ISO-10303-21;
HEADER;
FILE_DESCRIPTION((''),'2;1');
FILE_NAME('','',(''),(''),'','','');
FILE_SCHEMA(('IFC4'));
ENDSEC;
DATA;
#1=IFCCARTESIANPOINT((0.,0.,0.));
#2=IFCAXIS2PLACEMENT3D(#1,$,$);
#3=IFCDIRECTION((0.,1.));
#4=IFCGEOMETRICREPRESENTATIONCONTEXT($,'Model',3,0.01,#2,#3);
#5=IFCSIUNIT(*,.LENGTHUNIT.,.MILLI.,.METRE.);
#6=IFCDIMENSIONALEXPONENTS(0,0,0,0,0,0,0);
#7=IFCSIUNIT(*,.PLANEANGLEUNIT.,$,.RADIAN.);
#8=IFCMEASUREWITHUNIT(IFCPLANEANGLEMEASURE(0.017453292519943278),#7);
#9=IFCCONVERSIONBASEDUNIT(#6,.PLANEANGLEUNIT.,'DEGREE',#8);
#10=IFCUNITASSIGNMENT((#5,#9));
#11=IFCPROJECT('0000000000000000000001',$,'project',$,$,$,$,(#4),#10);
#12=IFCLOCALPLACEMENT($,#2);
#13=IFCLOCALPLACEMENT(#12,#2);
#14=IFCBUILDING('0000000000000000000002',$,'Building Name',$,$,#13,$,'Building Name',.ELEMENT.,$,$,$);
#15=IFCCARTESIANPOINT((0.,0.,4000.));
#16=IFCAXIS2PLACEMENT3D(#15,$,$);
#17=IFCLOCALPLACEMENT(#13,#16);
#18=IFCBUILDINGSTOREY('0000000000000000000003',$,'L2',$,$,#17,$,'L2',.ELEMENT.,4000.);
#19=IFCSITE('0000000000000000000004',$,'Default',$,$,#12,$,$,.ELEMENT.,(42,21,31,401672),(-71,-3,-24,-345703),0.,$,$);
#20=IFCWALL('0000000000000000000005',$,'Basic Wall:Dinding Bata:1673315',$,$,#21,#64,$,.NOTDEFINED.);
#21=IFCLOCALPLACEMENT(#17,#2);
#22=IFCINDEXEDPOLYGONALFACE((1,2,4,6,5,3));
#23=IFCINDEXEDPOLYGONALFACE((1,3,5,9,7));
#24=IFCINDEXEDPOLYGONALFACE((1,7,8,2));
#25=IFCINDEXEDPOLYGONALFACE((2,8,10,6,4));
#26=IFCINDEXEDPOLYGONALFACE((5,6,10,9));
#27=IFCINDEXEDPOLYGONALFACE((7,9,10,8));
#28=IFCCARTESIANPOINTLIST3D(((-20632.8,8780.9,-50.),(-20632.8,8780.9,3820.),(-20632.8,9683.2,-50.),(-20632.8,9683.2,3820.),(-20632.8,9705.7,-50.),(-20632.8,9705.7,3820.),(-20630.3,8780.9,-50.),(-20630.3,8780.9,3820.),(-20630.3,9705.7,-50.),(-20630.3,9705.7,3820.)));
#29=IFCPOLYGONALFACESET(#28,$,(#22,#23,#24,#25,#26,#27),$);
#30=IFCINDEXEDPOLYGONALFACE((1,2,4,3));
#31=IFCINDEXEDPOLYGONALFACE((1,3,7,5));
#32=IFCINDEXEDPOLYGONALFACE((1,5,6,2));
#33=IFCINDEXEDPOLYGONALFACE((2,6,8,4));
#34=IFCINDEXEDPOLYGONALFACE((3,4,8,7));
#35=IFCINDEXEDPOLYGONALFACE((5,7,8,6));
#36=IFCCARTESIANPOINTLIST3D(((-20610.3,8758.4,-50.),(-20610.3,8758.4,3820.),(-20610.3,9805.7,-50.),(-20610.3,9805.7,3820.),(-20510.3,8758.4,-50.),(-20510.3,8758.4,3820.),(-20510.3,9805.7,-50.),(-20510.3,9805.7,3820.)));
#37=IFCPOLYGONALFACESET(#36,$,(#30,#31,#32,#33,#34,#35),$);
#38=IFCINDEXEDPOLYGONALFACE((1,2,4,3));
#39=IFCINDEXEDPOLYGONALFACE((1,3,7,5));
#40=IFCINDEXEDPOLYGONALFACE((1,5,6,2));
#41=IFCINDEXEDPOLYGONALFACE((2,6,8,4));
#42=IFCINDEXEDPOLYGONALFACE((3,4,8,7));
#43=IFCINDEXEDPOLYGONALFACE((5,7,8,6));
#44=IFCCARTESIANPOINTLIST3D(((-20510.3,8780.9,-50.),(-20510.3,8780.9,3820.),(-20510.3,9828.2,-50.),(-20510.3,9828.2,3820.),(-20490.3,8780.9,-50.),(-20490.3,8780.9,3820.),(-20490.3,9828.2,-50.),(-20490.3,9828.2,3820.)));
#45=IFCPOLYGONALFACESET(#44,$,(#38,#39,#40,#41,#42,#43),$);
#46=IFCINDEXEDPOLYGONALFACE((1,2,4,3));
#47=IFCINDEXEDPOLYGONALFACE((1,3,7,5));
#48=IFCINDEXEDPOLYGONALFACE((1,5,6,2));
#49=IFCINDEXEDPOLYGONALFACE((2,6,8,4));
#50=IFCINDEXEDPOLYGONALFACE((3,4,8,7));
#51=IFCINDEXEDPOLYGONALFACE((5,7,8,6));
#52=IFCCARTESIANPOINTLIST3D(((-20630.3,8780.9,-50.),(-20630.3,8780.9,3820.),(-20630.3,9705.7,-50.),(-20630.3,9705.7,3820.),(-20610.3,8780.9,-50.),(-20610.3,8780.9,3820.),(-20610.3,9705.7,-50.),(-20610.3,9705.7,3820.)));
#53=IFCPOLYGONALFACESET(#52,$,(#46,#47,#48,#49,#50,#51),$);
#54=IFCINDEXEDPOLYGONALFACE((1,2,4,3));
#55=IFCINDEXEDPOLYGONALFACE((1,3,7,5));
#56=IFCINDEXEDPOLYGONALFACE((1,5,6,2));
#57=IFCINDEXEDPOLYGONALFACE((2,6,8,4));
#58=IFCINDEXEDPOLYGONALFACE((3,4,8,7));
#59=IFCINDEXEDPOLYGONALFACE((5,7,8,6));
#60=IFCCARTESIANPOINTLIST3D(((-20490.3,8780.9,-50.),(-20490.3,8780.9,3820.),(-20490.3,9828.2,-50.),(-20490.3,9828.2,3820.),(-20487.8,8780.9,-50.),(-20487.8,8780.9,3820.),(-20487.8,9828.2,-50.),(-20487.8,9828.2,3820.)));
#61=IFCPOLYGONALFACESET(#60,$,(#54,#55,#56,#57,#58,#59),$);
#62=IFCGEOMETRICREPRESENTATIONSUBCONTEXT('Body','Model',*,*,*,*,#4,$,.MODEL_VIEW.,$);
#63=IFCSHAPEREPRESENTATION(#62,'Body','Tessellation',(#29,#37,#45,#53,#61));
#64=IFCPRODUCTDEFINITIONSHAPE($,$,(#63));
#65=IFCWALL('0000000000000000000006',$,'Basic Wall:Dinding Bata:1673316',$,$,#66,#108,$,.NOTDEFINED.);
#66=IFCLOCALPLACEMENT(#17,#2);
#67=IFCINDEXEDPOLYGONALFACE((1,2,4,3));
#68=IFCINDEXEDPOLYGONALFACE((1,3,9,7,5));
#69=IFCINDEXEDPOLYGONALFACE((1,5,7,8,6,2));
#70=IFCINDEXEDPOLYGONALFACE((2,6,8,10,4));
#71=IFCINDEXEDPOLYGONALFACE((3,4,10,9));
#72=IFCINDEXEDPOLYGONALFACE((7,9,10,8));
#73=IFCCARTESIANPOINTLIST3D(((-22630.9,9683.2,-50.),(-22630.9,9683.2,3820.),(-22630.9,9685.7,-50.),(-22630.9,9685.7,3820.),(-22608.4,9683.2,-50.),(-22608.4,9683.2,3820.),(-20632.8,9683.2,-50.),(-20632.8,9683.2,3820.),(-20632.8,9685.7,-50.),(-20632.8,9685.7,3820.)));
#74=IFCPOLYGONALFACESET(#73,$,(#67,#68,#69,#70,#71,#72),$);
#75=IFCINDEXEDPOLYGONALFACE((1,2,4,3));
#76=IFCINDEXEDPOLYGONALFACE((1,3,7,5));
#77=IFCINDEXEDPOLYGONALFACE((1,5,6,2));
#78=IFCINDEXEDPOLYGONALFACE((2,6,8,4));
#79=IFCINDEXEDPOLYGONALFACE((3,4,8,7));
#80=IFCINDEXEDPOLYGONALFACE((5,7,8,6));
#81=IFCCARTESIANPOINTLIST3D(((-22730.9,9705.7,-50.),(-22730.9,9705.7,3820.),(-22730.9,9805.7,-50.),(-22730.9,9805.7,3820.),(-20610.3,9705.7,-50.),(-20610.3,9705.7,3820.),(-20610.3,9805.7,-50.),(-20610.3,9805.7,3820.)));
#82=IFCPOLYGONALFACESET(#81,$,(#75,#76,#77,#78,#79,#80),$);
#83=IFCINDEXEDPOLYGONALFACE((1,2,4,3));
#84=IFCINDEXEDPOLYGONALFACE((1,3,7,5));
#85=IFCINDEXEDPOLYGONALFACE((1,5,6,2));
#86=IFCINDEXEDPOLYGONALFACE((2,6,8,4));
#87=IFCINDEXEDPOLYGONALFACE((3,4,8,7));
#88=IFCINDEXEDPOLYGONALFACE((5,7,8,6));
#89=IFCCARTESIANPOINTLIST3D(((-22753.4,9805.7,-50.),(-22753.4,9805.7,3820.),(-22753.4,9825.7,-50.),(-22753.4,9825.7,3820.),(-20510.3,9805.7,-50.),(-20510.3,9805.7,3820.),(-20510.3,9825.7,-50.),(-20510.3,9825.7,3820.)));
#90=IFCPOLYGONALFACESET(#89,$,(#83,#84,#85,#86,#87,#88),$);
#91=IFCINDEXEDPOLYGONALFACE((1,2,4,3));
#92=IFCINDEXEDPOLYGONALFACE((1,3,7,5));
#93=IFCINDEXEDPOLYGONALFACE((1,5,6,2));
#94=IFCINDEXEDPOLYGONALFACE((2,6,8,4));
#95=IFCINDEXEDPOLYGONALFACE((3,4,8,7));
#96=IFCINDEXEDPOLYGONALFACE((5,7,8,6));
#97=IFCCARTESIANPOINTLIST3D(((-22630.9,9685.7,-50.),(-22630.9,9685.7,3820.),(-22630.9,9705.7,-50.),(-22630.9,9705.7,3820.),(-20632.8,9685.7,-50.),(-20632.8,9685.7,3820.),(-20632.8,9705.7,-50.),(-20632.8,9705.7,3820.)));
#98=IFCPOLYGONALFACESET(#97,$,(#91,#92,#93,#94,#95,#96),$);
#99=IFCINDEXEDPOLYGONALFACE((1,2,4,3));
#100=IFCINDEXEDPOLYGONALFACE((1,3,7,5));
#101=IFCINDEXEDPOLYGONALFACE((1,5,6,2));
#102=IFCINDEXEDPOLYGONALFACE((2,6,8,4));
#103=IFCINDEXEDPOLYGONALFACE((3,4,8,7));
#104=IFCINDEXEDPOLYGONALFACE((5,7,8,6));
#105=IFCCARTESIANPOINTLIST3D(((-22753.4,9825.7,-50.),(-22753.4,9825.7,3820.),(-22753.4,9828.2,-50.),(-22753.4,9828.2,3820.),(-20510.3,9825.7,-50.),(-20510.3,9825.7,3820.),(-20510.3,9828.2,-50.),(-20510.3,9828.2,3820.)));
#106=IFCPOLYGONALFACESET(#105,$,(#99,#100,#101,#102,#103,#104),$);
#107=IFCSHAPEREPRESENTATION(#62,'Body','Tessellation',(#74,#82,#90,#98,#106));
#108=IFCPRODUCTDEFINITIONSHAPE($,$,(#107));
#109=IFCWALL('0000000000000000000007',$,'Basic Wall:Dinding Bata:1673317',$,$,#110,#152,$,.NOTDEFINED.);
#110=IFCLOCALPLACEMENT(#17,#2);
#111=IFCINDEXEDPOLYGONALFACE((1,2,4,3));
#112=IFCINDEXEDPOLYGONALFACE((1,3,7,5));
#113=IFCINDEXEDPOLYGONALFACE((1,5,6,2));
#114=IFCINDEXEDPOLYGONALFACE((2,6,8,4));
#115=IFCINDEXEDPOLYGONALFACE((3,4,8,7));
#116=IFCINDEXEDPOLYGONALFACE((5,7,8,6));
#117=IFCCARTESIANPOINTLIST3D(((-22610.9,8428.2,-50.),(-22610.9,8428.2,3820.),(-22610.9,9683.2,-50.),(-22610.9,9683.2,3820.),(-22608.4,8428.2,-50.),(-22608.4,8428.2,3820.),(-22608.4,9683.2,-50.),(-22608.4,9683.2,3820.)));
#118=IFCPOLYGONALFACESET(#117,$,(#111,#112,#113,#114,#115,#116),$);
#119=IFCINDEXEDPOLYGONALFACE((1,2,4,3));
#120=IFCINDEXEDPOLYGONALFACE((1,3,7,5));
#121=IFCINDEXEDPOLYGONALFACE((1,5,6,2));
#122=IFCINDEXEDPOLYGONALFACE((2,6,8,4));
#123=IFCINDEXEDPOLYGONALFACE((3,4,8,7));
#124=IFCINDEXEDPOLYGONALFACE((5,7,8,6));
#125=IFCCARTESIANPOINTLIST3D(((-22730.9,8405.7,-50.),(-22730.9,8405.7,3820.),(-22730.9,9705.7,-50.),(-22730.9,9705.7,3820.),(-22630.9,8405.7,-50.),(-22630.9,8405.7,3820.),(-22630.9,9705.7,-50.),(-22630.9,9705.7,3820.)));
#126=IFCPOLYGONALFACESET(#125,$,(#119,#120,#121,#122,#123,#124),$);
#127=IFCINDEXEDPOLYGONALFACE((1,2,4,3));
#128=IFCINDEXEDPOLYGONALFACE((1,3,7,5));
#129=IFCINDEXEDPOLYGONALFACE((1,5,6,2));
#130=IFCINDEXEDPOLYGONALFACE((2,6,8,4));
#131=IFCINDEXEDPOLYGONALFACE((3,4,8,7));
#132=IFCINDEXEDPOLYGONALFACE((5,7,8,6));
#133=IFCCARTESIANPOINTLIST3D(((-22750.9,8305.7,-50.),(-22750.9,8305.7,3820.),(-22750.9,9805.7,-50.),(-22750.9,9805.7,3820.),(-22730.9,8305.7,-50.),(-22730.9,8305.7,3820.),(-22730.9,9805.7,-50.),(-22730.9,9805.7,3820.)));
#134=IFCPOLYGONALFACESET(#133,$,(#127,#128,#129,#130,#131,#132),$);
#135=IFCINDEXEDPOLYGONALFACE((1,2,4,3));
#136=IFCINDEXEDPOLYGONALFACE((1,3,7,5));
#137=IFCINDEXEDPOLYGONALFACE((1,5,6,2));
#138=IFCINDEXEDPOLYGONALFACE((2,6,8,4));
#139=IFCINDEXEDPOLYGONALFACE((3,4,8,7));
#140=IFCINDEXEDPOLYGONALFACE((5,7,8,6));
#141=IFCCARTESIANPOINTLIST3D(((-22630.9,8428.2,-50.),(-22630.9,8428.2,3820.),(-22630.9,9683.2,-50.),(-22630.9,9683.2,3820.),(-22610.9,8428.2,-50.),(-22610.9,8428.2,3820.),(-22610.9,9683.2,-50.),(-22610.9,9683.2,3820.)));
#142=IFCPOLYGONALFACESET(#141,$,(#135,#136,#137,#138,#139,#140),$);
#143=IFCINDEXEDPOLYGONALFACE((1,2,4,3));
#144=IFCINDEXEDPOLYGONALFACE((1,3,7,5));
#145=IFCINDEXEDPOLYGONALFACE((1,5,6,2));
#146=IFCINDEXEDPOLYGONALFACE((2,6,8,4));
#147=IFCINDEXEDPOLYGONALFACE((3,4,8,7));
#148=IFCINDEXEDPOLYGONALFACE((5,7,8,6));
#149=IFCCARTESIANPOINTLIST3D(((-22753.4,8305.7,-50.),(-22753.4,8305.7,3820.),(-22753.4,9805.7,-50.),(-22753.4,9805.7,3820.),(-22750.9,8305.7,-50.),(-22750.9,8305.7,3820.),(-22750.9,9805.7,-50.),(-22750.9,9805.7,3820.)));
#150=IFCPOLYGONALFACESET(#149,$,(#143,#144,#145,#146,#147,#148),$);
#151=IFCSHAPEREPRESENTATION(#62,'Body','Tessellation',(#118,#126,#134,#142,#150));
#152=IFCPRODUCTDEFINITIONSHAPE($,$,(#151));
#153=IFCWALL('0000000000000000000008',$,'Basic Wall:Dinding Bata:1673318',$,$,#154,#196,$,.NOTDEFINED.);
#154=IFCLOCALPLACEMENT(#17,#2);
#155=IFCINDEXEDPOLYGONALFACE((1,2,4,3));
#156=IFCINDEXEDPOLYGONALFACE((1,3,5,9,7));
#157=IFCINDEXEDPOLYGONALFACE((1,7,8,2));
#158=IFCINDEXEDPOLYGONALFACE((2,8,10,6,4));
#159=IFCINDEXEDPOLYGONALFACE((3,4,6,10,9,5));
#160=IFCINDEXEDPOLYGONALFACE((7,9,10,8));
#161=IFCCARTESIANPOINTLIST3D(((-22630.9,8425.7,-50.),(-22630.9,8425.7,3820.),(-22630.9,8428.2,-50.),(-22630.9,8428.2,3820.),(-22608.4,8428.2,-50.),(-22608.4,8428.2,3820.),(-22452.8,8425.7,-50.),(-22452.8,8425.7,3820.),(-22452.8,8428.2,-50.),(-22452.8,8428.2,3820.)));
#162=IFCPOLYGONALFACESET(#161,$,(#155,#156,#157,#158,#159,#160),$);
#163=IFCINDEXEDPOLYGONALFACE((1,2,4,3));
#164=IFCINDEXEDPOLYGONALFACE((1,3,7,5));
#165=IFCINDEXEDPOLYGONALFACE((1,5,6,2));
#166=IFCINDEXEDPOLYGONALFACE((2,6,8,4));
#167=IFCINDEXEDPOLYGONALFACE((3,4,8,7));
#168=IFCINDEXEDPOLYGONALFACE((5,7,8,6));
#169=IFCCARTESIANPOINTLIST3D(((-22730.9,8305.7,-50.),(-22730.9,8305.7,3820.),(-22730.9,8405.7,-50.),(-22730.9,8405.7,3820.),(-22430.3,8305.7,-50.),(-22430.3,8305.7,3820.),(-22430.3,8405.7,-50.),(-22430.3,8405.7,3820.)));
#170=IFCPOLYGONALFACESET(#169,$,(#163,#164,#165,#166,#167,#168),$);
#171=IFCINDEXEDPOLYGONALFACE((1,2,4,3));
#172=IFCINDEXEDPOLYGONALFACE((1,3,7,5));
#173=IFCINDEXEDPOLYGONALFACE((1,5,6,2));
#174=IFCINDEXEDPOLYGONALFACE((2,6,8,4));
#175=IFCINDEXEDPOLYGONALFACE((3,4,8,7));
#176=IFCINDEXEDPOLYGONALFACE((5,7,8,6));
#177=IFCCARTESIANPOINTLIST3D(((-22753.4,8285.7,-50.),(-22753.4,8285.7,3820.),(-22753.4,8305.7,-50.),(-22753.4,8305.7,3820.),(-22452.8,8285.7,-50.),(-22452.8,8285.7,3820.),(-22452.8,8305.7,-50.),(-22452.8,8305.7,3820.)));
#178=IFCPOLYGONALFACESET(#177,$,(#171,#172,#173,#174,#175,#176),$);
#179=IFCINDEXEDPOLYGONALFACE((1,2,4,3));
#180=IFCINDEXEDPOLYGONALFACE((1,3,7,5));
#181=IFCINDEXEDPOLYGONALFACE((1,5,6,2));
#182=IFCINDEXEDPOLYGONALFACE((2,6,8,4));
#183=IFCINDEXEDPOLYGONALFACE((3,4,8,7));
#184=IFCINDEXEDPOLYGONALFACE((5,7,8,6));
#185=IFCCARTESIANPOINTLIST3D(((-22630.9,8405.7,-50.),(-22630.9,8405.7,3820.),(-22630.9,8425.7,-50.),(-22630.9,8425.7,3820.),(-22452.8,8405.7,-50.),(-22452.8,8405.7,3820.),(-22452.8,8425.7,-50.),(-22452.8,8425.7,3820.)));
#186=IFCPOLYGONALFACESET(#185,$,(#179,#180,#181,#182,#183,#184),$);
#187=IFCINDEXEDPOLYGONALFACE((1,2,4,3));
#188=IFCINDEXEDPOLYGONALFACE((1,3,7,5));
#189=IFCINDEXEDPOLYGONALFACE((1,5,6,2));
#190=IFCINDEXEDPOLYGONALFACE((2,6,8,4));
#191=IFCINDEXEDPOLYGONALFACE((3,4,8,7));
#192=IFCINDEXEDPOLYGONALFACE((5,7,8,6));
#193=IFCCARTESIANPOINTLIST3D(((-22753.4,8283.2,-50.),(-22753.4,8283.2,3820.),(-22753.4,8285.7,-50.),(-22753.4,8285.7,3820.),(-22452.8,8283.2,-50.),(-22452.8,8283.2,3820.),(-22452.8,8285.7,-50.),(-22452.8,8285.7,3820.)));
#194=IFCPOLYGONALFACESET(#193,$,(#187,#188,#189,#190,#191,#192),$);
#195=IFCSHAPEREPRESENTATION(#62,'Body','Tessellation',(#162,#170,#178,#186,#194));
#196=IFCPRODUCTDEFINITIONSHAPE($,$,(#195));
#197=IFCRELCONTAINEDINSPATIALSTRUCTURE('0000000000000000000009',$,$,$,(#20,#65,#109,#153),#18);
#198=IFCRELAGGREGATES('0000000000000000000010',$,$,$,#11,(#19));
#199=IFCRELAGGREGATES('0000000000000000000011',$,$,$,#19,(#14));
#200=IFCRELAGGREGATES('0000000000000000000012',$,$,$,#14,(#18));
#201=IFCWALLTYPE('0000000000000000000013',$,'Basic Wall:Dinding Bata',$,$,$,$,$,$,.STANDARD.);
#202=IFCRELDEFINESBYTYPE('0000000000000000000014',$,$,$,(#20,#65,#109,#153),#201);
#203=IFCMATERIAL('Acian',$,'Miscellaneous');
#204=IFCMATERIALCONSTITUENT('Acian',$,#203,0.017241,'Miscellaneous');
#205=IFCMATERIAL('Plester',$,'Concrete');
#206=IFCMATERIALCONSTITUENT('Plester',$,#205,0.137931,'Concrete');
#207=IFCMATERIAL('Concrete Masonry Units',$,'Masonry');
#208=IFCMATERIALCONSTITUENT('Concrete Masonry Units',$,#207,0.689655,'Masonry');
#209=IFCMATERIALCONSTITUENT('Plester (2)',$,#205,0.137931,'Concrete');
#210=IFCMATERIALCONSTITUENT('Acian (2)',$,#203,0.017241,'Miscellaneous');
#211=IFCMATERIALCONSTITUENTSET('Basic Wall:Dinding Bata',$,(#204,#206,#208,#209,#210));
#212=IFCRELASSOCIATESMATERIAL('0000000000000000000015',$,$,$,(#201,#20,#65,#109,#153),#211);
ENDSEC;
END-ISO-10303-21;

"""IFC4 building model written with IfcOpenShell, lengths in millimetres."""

from ifc_helpers import new_model, entity, si_unit, converted_unit, direction, frame, origin, place, context, subcontext, project, spatial, indexed_curve, outline, extrude, material, constituent, constituent_set, type_object, element, save


model = new_model("IFC4")

# Units and contexts
model_context = context("Model", 3, precision=0.01, world=origin(), true_north=direction((0.0, 1.0)))
body_context = subcontext(model_context, "Body", "Model", "MODEL_VIEW")
ifc_project = project(units=[si_unit("LENGTHUNIT", "METRE", prefix="MILLI"), converted_unit("PLANEANGLEUNIT", "DEGREE", entity("IfcPlaneAngleMeasure", 0.017453292519943278), si_unit("PLANEANGLEUNIT", "RADIAN"), dimensions=[0, 0, 0, 0, 0, 0, 0])], contexts=[model_context])

# Site, building, storey
site_placement = place(None, origin())
site = spatial("IfcSite", under=ifc_project, at=site_placement, Name="Default", CompositionType="ELEMENT", RefLatitude=(42, 21, 31, 401672), RefLongitude=(-71, -3, -24, -345703), RefElevation=0.0)
building_placement = place(site_placement, origin())
building = spatial("IfcBuilding", under=site, at=building_placement, Name="Building Name", LongName="Building Name", CompositionType="ELEMENT")
storey_placement = place(building_placement, frame((0.0, 0.0, 4000.0)))
storey = spatial("IfcBuildingStorey", under=building, at=storey_placement, Name="L2", LongName="L2", CompositionType="ELEMENT", Elevation=4000.0)

# Walls
ifc_material_1 = material(Name="Acian", Category="Miscellaneous")
ifc_constituent_1 = constituent(ifc_material_1, Name="Acian", Category="Miscellaneous", fraction=0.017241)
ifc_material_2 = material(Name="Plester", Category="Concrete")
ifc_constituent_2 = constituent(ifc_material_2, Name="Plester", Category="Concrete", fraction=0.137931)
ifc_material_3 = material(Name="Concrete Masonry Units", Category="Masonry")
ifc_constituent_3 = constituent(ifc_material_3, Name="Concrete Masonry Units", Category="Masonry", fraction=0.689655)
ifc_constituent_4 = constituent(ifc_material_2, Name="Plester (2)", Category="Concrete", fraction=0.137931)
ifc_constituent_5 = constituent(ifc_material_1, Name="Acian (2)", Category="Miscellaneous", fraction=0.017241)
ifc_constituent_set = constituent_set(constituents=[ifc_constituent_1, ifc_constituent_2, ifc_constituent_3, ifc_constituent_4, ifc_constituent_5], Name="Basic Wall:Dinding Bata")
wall_type = type_object("IfcWallType", Name="Basic Wall:Dinding Bata", PredefinedType="STANDARD", material=ifc_constituent_set)
wall_1_placement = place(storey_placement, frame((-20560.3, 8780.9, -50.0), z_axis=(0.0, 0.0, 1.0), x_axis=(0.0, 1.0, 0.0)))
element("IfcWall", 1, at=wall_1_placement, inside=storey, type_object=wall_type, material=ifc_constituent_set, Name="Basic Wall:Dinding Bata:1673315", PredefinedType="NOTDEFINED", context=body_context, shape_type="SweptSolid", body=[
    extrude(outline(indexed_curve([(-351.9, -1.0), (550.4, -1.0), (550.4, 1.5), (-374.4, 1.5), (-374.4, -1.0), (-351.9, -1.0)], self_intersect=False)), frame((550.4, 71.5, 0.0), z_axis=(0.0, 0.0, 1.0), x_axis=(-1.0, 0.0, 0.0)), (0.0, 0.0, 1.0), 3870.0),
    extrude(outline(indexed_curve([(-523.7, -50.0), (523.7, -50.0), (523.7, 50.0), (-523.7, 50.0), (-523.7, -50.0)], self_intersect=False)), frame((501.2, 0.0, 0.0)), (0.0, 0.0, 1.0), 3870.0),
    extrude(outline(indexed_curve([(-523.7, -10.0), (523.7, -10.0), (523.7, 10.0), (-523.7, 10.0), (-523.7, -10.0)], self_intersect=False)), frame((523.7, -60.0, 0.0)), (0.0, 0.0, 1.0), 3870.0),
    extrude(outline(indexed_curve([(-462.4, -10.0), (462.4, -10.0), (462.4, 10.0), (-462.4, 10.0), (-462.4, -10.0)], self_intersect=False)), frame((462.4, 60.0, 0.0)), (0.0, 0.0, 1.0), 3870.0),
    extrude(outline(indexed_curve([(-1.2, -523.7), (1.2, -523.7), (1.2, 523.7), (-1.2, 523.7), (-1.2, -523.7)], self_intersect=False)), frame((523.7, -71.3, 0.0), z_axis=(0.0, 0.0, 1.0), x_axis=(0.0, 1.0, 0.0)), (0.0, 0.0, 1.0), 3870.0),
])
wall_2_placement = place(storey_placement, frame((-20632.8, 9755.7, -50.0), z_axis=(0.0, 0.0, 1.0), x_axis=(-1.0, 0.0, 0.0)))
element("IfcWall", 2, at=wall_2_placement, inside=storey, type_object=wall_type, material=ifc_constituent_set, Name="Basic Wall:Dinding Bata:1673316", PredefinedType="NOTDEFINED", context=body_context, shape_type="SweptSolid", body=[
    extrude(outline(indexed_curve([(-781.2, -1.0), (1194.4, -1.0), (1194.4, 1.5), (-803.7, 1.5), (-803.7, -1.0), (-781.2, -1.0)], self_intersect=False)), frame((1194.4, 71.5, 0.0), z_axis=(0.0, 0.0, 1.0), x_axis=(-1.0, 0.0, 0.0)), (0.0, 0.0, 1.0), 3870.0),
    extrude(outline(indexed_curve([(-1060.3, -50.0), (1060.3, -50.0), (1060.3, 50.0), (-1060.3, 50.0), (-1060.3, -50.0)], self_intersect=False)), frame((1037.8, 0.0, 0.0)), (0.0, 0.0, 1.0), 3870.0),
    extrude(outline(indexed_curve([(-1121.5, -10.0), (1121.5, -10.0), (1121.5, 10.0), (-1121.5, 10.0), (-1121.5, -10.0)], self_intersect=False)), frame((999.0, -60.0, 0.0)), (0.0, 0.0, 1.0), 3870.0),
    extrude(outline(indexed_curve([(-999.0, -10.0), (999.0, -10.0), (999.0, 10.0), (-999.0, 10.0), (-999.0, -10.0)], self_intersect=False)), frame((999.0, 60.0, 0.0)), (0.0, 0.0, 1.0), 3870.0),
    extrude(outline(indexed_curve([(-1.3, -1121.5), (1.2, -1121.5), (1.3, 1121.5), (-1.2, 1121.5), (-1.3, -1121.5)], self_intersect=False)), frame((999.0, -71.2, 0.0), z_axis=(0.0, 0.0, 1.0), x_axis=(0.0, 1.0, 0.0)), (0.0, 0.0, 1.0), 3870.0),
])
wall_3_placement = place(storey_placement, frame((-22680.9, 9683.2, -50.0), z_axis=(0.0, 0.0, 1.0), x_axis=(0.0, -1.0, 0.0)))
element("IfcWall", 3, at=wall_3_placement, inside=storey, type_object=wall_type, material=ifc_constituent_set, Name="Basic Wall:Dinding Bata:1673317", PredefinedType="NOTDEFINED", context=body_context, shape_type="SweptSolid", body=[
    extrude(outline(indexed_curve([(-1.2, -627.5), (1.2, -627.5), (1.3, 627.5), (-1.2, 627.5), (-1.2, -627.5)], self_intersect=False)), frame((627.5, 71.3, 0.0), z_axis=(0.0, 0.0, 1.0), x_axis=(0.0, -1.0, 0.0)), (0.0, 0.0, 1.0), 3870.0),
    extrude(outline(indexed_curve([(-650.0, -50.0), (650.0, -50.0), (650.0, 50.0), (-650.0, 50.0), (-650.0, -50.0)], self_intersect=False)), frame((627.5, 0.0, 0.0)), (0.0, 0.0, 1.0), 3870.0),
    extrude(outline(indexed_curve([(-750.0, -10.0), (750.0, -10.0), (750.0, 10.0), (-750.0, 10.0), (-750.0, -10.0)], self_intersect=False)), frame((627.5, -60.0, 0.0)), (0.0, 0.0, 1.0), 3870.0),
    extrude(outline(indexed_curve([(-627.5, -10.0), (627.5, -10.0), (627.5, 10.0), (-627.5, 10.0), (-627.5, -10.0)], self_intersect=False)), frame((627.5, 60.0, 0.0)), (0.0, 0.0, 1.0), 3870.0),
    extrude(outline(indexed_curve([(-1.3, -750.0), (1.2, -750.0), (1.2, 750.0), (-1.2, 750.0), (-1.3, -750.0)], self_intersect=False)), frame((627.5, -71.2, 0.0), z_axis=(0.0, 0.0, 1.0), x_axis=(0.0, 1.0, 0.0)), (0.0, 0.0, 1.0), 3870.0),
])
wall_4_placement = place(storey_placement, frame((-22753.4, 8355.7, -50.0)))
element("IfcWall", 4, at=wall_4_placement, inside=storey, type_object=wall_type, material=ifc_constituent_set, Name="Basic Wall:Dinding Bata:1673318", PredefinedType="NOTDEFINED", context=body_context, shape_type="SweptSolid", body=[
    extrude(outline(indexed_curve([(53.2, -1.0), (75.7, -1.0), (75.7, 1.5), (-102.4, 1.5), (-102.4, -1.0), (53.2, -1.0)], self_intersect=False)), frame((198.2, 71.5, 0.0), z_axis=(0.0, 0.0, 1.0), x_axis=(-1.0, 0.0, 0.0)), (0.0, 0.0, 1.0), 3870.0),
    extrude(outline(indexed_curve([(-150.3, -50.0), (150.3, -50.0), (150.3, 50.0), (-150.3, 50.0), (-150.3, -50.0)], self_intersect=False)), frame((172.8, 0.0, 0.0)), (0.0, 0.0, 1.0), 3870.0),
    extrude(outline(indexed_curve([(-150.3, -10.0), (150.3, -10.0), (150.3, 10.0), (-150.3, 10.0), (-150.3, -10.0)], self_intersect=False)), frame((150.3, -60.0, 0.0)), (0.0, 0.0, 1.0), 3870.0),
    extrude(outline(indexed_curve([(-89.0, -10.0), (89.0, -10.0), (89.0, 10.0), (-89.0, 10.0), (-89.0, -10.0)], self_intersect=False)), frame((211.5, 60.0, 0.0)), (0.0, 0.0, 1.0), 3870.0),
    extrude(outline(indexed_curve([(-1.2, -150.3), (1.2, -150.3), (1.3, 150.3), (-1.2, 150.3), (-1.2, -150.3)], self_intersect=False)), frame((150.3, -71.3, 0.0), z_axis=(0.0, 0.0, 1.0), x_axis=(0.0, 1.0, 0.0)), (0.0, 0.0, 1.0), 3870.0),
])

save(model, "model.ifc")
